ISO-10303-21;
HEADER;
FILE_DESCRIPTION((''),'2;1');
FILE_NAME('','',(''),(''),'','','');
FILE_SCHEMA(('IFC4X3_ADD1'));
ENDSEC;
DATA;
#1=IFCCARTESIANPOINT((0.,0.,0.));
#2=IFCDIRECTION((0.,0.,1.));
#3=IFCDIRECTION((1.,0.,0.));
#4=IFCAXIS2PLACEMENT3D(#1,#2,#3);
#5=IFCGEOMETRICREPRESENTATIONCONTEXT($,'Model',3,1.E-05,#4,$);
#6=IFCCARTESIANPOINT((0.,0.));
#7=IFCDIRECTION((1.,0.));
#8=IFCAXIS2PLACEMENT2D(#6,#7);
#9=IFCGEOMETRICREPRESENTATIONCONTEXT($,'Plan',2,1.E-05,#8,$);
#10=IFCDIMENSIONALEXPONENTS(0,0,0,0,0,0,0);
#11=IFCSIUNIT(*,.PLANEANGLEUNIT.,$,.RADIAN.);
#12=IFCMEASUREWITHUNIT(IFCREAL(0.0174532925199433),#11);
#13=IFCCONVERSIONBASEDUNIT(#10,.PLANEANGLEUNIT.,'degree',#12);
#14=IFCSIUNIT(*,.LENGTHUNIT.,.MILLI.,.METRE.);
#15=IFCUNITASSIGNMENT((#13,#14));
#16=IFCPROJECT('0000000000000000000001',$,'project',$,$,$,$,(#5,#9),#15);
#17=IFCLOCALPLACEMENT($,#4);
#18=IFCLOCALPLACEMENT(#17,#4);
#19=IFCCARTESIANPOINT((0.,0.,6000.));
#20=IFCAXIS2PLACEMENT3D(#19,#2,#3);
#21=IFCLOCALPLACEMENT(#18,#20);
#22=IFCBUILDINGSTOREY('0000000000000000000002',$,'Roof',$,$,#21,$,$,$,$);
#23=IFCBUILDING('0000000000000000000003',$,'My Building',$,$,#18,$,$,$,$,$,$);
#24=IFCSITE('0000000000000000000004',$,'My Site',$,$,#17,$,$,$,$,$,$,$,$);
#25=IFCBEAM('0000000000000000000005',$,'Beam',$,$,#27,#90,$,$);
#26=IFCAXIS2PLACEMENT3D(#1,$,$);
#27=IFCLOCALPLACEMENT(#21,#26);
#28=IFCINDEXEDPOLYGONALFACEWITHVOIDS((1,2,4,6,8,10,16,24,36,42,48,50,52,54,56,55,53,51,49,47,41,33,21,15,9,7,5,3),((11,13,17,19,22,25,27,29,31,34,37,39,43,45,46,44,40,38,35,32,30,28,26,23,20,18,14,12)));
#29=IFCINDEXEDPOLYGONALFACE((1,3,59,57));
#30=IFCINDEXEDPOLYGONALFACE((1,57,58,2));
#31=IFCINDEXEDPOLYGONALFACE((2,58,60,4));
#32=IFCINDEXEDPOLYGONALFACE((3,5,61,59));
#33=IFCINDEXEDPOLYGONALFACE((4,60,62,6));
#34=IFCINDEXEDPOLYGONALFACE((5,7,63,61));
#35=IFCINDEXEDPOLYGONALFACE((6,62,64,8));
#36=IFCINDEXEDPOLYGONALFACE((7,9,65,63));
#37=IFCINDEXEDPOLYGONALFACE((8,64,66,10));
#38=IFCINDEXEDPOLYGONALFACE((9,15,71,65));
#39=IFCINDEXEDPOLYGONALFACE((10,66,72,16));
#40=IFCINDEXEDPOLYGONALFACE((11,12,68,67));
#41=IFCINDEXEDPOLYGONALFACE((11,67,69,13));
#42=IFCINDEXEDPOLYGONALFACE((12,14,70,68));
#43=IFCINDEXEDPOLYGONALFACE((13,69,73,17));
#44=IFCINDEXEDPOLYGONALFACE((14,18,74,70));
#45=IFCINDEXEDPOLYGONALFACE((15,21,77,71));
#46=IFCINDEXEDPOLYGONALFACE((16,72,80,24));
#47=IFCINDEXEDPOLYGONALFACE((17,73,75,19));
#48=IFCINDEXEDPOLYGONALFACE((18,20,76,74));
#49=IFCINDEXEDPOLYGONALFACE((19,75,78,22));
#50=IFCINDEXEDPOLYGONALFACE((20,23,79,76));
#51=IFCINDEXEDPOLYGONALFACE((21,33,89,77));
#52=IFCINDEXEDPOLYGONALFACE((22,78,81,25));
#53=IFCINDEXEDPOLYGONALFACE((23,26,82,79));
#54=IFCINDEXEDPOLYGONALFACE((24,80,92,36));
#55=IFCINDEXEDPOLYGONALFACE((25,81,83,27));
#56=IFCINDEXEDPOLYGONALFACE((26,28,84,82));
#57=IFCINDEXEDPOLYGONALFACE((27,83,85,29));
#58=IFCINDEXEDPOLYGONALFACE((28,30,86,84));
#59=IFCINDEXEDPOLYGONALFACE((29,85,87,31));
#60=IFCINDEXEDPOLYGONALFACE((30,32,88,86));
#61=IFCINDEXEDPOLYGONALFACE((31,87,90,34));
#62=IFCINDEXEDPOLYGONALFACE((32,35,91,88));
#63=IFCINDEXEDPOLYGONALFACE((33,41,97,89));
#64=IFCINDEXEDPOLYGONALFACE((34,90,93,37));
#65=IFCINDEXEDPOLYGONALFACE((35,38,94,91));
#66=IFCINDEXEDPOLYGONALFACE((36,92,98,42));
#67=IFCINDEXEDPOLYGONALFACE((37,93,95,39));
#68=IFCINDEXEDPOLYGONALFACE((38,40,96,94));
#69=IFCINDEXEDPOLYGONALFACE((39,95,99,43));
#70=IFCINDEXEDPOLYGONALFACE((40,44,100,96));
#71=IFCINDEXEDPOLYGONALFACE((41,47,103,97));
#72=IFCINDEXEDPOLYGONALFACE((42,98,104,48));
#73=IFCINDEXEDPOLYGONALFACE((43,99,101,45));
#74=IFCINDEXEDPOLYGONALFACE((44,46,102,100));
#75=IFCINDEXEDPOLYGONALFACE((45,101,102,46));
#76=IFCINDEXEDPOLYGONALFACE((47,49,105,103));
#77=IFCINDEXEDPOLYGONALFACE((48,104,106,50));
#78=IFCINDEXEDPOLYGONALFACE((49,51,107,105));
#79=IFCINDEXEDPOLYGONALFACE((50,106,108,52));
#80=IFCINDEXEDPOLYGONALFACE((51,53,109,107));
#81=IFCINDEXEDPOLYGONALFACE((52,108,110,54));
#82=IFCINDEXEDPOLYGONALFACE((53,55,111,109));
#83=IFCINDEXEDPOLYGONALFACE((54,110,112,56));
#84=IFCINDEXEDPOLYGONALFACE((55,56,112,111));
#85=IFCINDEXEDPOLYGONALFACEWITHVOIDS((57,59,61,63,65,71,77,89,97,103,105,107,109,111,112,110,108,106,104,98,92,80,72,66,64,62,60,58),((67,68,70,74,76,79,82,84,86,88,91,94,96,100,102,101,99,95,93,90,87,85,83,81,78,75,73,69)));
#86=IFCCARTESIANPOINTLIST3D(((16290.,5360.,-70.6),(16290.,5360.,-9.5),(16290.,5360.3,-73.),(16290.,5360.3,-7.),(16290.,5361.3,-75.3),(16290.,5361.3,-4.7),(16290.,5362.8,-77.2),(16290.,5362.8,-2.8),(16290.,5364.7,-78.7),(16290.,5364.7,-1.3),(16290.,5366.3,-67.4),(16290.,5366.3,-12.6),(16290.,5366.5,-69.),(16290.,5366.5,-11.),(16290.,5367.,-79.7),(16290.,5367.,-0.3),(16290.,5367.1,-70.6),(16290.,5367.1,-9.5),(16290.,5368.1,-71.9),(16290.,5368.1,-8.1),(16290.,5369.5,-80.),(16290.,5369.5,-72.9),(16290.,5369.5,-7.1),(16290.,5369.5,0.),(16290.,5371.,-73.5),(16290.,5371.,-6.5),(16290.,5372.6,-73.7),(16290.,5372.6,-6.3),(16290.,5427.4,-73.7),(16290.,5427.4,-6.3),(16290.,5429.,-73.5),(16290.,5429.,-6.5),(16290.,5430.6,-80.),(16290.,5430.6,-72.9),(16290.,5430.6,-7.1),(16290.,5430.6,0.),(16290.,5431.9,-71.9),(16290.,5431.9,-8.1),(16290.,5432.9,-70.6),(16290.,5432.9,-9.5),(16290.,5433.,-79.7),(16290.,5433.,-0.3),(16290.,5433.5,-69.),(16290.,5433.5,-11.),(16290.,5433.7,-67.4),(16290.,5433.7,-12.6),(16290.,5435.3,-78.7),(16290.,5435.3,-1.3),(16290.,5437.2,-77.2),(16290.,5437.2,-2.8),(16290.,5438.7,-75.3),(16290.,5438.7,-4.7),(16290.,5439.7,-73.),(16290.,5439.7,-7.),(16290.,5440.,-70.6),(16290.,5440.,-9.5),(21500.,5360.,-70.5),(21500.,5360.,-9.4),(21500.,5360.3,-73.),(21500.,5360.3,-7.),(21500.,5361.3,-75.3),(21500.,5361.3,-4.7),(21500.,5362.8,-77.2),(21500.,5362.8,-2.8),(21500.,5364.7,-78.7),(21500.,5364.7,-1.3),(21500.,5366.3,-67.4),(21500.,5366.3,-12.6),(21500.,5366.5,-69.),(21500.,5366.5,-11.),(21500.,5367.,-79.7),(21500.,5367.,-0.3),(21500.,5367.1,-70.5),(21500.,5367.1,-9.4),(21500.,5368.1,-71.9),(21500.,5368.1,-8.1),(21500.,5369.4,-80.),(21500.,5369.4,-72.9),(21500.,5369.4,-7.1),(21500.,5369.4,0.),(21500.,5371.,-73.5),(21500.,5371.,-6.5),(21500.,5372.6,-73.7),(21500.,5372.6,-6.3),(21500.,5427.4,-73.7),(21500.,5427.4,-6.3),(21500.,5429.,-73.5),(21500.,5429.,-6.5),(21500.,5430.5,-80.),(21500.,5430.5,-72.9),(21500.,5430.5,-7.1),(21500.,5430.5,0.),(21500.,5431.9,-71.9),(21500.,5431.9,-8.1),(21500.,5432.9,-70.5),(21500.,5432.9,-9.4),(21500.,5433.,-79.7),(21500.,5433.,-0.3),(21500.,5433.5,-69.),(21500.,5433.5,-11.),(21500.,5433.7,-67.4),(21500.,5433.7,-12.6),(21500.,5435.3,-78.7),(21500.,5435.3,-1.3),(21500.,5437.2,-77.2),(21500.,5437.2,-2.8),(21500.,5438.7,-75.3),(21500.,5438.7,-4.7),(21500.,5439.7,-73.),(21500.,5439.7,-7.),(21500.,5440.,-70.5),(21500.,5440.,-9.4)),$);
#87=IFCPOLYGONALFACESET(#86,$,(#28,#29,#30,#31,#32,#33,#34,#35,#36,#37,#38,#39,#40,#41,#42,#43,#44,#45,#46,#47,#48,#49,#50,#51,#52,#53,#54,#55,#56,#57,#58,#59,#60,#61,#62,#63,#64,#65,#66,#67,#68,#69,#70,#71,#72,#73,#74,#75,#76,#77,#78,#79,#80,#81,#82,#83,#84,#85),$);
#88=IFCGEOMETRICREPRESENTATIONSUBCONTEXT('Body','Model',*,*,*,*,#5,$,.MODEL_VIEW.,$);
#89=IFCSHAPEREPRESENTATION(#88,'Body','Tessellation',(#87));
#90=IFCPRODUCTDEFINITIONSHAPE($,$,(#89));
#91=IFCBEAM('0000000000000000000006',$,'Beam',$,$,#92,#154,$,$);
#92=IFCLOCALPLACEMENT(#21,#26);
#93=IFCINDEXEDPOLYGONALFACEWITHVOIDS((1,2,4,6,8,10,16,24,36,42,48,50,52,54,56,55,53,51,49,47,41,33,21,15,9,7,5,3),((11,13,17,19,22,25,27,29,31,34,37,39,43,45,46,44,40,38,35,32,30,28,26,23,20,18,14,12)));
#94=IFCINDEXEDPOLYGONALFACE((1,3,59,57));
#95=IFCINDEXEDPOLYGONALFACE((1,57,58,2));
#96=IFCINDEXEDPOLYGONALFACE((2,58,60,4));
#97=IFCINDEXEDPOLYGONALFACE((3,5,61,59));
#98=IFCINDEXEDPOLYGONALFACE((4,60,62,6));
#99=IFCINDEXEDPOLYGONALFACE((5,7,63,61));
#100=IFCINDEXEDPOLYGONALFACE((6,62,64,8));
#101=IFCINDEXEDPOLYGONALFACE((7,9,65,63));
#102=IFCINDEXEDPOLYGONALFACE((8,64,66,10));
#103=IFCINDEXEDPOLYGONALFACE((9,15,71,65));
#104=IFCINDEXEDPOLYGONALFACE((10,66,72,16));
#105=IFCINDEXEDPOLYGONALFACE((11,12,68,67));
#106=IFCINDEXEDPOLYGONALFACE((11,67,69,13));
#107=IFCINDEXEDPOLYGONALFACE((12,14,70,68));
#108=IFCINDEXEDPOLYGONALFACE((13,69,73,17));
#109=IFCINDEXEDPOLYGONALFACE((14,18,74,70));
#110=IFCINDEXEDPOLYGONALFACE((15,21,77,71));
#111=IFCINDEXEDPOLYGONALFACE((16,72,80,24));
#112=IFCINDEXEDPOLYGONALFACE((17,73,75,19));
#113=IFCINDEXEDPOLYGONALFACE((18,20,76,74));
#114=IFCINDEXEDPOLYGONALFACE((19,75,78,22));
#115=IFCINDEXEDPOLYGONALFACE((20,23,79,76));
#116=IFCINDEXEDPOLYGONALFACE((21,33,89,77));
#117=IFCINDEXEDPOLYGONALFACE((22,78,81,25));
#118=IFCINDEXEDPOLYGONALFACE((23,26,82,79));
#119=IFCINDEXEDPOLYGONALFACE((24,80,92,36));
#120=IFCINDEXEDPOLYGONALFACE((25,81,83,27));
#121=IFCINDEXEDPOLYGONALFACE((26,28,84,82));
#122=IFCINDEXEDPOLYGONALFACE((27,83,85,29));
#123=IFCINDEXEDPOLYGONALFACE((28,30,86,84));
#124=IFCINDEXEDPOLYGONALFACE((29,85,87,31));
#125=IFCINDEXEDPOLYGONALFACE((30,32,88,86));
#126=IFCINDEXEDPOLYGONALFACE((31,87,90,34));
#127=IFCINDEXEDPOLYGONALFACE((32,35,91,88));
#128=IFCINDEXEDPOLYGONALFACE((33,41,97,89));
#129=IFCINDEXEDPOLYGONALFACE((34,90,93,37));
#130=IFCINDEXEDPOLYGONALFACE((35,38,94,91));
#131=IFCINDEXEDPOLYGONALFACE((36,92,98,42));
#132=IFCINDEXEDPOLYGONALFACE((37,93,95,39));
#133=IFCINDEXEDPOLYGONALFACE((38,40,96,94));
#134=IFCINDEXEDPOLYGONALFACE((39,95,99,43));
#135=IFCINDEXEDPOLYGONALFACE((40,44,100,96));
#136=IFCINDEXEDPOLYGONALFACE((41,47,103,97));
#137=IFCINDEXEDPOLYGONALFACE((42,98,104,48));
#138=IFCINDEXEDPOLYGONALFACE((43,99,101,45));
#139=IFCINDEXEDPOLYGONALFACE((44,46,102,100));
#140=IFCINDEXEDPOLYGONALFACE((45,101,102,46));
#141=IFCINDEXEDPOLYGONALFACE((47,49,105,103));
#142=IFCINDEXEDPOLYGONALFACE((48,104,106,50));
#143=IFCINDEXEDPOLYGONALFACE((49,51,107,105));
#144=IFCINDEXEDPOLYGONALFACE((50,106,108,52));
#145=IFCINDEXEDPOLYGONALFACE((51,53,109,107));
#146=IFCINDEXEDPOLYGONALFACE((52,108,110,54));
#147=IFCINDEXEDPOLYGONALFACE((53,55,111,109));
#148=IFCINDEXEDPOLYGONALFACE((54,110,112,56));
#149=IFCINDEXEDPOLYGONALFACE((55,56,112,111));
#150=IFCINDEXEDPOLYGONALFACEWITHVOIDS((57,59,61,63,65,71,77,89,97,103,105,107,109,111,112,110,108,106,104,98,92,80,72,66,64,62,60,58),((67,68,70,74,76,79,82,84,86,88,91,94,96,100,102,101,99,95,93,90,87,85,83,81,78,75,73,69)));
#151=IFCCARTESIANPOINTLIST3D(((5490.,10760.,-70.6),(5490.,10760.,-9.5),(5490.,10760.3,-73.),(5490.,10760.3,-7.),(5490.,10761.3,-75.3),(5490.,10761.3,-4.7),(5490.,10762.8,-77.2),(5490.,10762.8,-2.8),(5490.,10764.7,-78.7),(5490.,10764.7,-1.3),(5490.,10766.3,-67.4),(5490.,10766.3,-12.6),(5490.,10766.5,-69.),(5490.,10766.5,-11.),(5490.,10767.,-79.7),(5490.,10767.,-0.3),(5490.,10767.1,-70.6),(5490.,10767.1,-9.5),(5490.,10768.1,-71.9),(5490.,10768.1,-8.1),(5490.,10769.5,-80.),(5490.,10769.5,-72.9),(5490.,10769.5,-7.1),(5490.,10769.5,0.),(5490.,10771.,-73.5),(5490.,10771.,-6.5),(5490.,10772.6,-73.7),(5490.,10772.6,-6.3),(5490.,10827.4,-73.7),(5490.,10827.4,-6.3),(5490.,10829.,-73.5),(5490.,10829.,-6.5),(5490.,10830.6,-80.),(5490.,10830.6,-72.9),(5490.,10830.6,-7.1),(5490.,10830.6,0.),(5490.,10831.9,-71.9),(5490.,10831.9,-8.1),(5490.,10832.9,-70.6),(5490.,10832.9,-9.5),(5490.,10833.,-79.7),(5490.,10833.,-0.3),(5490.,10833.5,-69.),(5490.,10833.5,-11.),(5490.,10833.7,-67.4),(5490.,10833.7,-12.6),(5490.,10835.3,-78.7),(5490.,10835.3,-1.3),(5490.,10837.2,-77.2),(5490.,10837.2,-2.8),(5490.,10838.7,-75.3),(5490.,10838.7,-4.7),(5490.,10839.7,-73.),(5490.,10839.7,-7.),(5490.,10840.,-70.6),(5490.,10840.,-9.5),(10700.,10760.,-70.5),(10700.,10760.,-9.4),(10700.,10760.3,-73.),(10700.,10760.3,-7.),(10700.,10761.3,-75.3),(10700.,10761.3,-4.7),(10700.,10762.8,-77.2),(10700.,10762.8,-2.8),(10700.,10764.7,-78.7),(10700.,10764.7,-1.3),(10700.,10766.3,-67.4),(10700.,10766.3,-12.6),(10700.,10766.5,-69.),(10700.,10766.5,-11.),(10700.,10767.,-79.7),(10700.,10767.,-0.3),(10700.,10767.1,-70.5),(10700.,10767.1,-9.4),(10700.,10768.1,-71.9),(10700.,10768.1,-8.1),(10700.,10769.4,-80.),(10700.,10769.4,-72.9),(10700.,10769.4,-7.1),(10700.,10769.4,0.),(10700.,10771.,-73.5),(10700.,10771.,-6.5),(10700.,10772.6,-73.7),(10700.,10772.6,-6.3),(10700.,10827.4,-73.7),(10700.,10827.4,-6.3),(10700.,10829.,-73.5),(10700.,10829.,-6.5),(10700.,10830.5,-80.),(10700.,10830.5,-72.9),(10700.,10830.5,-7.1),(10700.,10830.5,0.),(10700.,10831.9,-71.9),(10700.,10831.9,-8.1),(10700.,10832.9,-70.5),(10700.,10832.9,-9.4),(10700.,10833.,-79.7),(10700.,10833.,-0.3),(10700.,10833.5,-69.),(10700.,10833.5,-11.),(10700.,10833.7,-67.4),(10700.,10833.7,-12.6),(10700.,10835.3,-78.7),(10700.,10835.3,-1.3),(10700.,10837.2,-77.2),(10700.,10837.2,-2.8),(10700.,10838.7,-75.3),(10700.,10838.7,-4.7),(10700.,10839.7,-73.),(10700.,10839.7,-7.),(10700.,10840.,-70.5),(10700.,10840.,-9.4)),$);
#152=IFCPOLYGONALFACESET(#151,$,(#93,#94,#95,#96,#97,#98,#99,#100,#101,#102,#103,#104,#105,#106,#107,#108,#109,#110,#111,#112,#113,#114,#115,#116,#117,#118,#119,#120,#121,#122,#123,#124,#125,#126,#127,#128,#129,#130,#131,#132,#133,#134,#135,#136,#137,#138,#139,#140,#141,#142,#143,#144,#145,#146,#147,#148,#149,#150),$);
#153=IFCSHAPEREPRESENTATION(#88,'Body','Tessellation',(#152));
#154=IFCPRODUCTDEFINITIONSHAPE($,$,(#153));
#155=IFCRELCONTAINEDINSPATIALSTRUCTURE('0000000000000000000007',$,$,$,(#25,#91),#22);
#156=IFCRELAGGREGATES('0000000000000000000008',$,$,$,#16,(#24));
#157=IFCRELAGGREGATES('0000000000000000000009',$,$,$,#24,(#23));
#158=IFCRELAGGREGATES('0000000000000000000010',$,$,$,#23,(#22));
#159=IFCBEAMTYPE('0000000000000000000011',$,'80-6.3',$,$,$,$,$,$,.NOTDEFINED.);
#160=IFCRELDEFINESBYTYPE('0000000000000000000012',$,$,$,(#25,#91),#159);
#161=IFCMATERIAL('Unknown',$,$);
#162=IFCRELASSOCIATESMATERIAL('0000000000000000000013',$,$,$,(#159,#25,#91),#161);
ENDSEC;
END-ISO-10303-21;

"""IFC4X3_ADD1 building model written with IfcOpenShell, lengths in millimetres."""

from ifc_helpers import new_model, entity, si_unit, converted_unit, frame, origin_with_axes, origin_2d_with_axis, place, context, subcontext, project, spatial, hollow_rectangle, extrude, material, material_profile, profile_set, profile_usage, type_object, element, save


model = new_model("IFC4X3_ADD1")

# Units and contexts
model_context = context("Model", 3, precision=1e-05, world=origin_with_axes())
plan_context = context("Plan", 2, precision=1e-05, world=origin_2d_with_axis())
body_context = subcontext(model_context, "Body", "Model", "MODEL_VIEW")
ifc_project = project(units=[converted_unit("PLANEANGLEUNIT", "degree", entity("IfcReal", 0.0174532925199433), si_unit("PLANEANGLEUNIT", "RADIAN"), dimensions=[0, 0, 0, 0, 0, 0, 0]), si_unit("LENGTHUNIT", "METRE", prefix="MILLI")], contexts=[model_context, plan_context])

# Site, building, storey
site_placement = place(None, origin_with_axes())
site = spatial("IfcSite", under=ifc_project, at=site_placement, Name="My Site")
building_placement = place(site_placement, origin_with_axes())
building = spatial("IfcBuilding", under=site, at=building_placement, Name="My Building")
storey_placement = place(building_placement, frame((0.0, 0.0, 6000.0), z_axis=(0.0, 0.0, 1.0), x_axis=(1.0, 0.0, 0.0)))
storey = spatial("IfcBuildingStorey", under=building, at=storey_placement, Name="Roof")

# Beams
ifc_material = material(Name="Unknown")
ifc_material_profile_1 = material_profile(ifc_material, hollow_rectangle(XDim=80.0, YDim=80.0, WallThickness=6.3, InnerFilletRadius=6.3, OuterFilletRadius=9.4))
ifc_profile_set_1 = profile_set([ifc_material_profile_1])
beam_type_1 = type_object("IfcBeamType", Name="80-6.3", PredefinedType="NOTDEFINED", material=ifc_profile_set_1)
ifc_profile_usage_1 = profile_usage(ifc_profile_set_1, cardinal=8)
beam_1_placement = place(storey_placement, frame((16290.0, 5400.0, 0.0), z_axis=(1.0, 0.0, 0.0), x_axis=(0.0, 1.0, 0.0)))
element("IfcBeam", 1, at=beam_1_placement, inside=storey, type_object=beam_type_1, material=ifc_profile_usage_1, Name="Beam", context=body_context, shape_type="SweptSolid", body=[
    extrude(hollow_rectangle(XDim=80.0, YDim=80.0, WallThickness=6.3, InnerFilletRadius=6.3, OuterFilletRadius=9.4), frame((0.0, -40.0, 0.0), z_axis=(0.0, 0.0, 1.0), x_axis=(1.0, 0.0, 0.0)), (0.0, 0.0, 1.0), 5210.0),
])
ifc_profile_usage_2 = profile_usage(ifc_profile_set_1, cardinal=8)
beam_2_placement = place(storey_placement, frame((5490.0, 10800.0, 0.0), z_axis=(1.0, 0.0, 0.0), x_axis=(0.0, 1.0, 0.0)))
element("IfcBeam", 2, at=beam_2_placement, inside=storey, type_object=beam_type_1, material=ifc_profile_usage_2, Name="Beam", context=body_context, shape_type="SweptSolid", body=[
    extrude(hollow_rectangle(XDim=80.0, YDim=80.0, WallThickness=6.3, InnerFilletRadius=6.3, OuterFilletRadius=9.4), frame((0.0, -40.0, 0.0), z_axis=(0.0, 0.0, 1.0), x_axis=(1.0, 0.0, 0.0)), (0.0, 0.0, 1.0), 5210.0),
])

save(model, "model.ifc")
